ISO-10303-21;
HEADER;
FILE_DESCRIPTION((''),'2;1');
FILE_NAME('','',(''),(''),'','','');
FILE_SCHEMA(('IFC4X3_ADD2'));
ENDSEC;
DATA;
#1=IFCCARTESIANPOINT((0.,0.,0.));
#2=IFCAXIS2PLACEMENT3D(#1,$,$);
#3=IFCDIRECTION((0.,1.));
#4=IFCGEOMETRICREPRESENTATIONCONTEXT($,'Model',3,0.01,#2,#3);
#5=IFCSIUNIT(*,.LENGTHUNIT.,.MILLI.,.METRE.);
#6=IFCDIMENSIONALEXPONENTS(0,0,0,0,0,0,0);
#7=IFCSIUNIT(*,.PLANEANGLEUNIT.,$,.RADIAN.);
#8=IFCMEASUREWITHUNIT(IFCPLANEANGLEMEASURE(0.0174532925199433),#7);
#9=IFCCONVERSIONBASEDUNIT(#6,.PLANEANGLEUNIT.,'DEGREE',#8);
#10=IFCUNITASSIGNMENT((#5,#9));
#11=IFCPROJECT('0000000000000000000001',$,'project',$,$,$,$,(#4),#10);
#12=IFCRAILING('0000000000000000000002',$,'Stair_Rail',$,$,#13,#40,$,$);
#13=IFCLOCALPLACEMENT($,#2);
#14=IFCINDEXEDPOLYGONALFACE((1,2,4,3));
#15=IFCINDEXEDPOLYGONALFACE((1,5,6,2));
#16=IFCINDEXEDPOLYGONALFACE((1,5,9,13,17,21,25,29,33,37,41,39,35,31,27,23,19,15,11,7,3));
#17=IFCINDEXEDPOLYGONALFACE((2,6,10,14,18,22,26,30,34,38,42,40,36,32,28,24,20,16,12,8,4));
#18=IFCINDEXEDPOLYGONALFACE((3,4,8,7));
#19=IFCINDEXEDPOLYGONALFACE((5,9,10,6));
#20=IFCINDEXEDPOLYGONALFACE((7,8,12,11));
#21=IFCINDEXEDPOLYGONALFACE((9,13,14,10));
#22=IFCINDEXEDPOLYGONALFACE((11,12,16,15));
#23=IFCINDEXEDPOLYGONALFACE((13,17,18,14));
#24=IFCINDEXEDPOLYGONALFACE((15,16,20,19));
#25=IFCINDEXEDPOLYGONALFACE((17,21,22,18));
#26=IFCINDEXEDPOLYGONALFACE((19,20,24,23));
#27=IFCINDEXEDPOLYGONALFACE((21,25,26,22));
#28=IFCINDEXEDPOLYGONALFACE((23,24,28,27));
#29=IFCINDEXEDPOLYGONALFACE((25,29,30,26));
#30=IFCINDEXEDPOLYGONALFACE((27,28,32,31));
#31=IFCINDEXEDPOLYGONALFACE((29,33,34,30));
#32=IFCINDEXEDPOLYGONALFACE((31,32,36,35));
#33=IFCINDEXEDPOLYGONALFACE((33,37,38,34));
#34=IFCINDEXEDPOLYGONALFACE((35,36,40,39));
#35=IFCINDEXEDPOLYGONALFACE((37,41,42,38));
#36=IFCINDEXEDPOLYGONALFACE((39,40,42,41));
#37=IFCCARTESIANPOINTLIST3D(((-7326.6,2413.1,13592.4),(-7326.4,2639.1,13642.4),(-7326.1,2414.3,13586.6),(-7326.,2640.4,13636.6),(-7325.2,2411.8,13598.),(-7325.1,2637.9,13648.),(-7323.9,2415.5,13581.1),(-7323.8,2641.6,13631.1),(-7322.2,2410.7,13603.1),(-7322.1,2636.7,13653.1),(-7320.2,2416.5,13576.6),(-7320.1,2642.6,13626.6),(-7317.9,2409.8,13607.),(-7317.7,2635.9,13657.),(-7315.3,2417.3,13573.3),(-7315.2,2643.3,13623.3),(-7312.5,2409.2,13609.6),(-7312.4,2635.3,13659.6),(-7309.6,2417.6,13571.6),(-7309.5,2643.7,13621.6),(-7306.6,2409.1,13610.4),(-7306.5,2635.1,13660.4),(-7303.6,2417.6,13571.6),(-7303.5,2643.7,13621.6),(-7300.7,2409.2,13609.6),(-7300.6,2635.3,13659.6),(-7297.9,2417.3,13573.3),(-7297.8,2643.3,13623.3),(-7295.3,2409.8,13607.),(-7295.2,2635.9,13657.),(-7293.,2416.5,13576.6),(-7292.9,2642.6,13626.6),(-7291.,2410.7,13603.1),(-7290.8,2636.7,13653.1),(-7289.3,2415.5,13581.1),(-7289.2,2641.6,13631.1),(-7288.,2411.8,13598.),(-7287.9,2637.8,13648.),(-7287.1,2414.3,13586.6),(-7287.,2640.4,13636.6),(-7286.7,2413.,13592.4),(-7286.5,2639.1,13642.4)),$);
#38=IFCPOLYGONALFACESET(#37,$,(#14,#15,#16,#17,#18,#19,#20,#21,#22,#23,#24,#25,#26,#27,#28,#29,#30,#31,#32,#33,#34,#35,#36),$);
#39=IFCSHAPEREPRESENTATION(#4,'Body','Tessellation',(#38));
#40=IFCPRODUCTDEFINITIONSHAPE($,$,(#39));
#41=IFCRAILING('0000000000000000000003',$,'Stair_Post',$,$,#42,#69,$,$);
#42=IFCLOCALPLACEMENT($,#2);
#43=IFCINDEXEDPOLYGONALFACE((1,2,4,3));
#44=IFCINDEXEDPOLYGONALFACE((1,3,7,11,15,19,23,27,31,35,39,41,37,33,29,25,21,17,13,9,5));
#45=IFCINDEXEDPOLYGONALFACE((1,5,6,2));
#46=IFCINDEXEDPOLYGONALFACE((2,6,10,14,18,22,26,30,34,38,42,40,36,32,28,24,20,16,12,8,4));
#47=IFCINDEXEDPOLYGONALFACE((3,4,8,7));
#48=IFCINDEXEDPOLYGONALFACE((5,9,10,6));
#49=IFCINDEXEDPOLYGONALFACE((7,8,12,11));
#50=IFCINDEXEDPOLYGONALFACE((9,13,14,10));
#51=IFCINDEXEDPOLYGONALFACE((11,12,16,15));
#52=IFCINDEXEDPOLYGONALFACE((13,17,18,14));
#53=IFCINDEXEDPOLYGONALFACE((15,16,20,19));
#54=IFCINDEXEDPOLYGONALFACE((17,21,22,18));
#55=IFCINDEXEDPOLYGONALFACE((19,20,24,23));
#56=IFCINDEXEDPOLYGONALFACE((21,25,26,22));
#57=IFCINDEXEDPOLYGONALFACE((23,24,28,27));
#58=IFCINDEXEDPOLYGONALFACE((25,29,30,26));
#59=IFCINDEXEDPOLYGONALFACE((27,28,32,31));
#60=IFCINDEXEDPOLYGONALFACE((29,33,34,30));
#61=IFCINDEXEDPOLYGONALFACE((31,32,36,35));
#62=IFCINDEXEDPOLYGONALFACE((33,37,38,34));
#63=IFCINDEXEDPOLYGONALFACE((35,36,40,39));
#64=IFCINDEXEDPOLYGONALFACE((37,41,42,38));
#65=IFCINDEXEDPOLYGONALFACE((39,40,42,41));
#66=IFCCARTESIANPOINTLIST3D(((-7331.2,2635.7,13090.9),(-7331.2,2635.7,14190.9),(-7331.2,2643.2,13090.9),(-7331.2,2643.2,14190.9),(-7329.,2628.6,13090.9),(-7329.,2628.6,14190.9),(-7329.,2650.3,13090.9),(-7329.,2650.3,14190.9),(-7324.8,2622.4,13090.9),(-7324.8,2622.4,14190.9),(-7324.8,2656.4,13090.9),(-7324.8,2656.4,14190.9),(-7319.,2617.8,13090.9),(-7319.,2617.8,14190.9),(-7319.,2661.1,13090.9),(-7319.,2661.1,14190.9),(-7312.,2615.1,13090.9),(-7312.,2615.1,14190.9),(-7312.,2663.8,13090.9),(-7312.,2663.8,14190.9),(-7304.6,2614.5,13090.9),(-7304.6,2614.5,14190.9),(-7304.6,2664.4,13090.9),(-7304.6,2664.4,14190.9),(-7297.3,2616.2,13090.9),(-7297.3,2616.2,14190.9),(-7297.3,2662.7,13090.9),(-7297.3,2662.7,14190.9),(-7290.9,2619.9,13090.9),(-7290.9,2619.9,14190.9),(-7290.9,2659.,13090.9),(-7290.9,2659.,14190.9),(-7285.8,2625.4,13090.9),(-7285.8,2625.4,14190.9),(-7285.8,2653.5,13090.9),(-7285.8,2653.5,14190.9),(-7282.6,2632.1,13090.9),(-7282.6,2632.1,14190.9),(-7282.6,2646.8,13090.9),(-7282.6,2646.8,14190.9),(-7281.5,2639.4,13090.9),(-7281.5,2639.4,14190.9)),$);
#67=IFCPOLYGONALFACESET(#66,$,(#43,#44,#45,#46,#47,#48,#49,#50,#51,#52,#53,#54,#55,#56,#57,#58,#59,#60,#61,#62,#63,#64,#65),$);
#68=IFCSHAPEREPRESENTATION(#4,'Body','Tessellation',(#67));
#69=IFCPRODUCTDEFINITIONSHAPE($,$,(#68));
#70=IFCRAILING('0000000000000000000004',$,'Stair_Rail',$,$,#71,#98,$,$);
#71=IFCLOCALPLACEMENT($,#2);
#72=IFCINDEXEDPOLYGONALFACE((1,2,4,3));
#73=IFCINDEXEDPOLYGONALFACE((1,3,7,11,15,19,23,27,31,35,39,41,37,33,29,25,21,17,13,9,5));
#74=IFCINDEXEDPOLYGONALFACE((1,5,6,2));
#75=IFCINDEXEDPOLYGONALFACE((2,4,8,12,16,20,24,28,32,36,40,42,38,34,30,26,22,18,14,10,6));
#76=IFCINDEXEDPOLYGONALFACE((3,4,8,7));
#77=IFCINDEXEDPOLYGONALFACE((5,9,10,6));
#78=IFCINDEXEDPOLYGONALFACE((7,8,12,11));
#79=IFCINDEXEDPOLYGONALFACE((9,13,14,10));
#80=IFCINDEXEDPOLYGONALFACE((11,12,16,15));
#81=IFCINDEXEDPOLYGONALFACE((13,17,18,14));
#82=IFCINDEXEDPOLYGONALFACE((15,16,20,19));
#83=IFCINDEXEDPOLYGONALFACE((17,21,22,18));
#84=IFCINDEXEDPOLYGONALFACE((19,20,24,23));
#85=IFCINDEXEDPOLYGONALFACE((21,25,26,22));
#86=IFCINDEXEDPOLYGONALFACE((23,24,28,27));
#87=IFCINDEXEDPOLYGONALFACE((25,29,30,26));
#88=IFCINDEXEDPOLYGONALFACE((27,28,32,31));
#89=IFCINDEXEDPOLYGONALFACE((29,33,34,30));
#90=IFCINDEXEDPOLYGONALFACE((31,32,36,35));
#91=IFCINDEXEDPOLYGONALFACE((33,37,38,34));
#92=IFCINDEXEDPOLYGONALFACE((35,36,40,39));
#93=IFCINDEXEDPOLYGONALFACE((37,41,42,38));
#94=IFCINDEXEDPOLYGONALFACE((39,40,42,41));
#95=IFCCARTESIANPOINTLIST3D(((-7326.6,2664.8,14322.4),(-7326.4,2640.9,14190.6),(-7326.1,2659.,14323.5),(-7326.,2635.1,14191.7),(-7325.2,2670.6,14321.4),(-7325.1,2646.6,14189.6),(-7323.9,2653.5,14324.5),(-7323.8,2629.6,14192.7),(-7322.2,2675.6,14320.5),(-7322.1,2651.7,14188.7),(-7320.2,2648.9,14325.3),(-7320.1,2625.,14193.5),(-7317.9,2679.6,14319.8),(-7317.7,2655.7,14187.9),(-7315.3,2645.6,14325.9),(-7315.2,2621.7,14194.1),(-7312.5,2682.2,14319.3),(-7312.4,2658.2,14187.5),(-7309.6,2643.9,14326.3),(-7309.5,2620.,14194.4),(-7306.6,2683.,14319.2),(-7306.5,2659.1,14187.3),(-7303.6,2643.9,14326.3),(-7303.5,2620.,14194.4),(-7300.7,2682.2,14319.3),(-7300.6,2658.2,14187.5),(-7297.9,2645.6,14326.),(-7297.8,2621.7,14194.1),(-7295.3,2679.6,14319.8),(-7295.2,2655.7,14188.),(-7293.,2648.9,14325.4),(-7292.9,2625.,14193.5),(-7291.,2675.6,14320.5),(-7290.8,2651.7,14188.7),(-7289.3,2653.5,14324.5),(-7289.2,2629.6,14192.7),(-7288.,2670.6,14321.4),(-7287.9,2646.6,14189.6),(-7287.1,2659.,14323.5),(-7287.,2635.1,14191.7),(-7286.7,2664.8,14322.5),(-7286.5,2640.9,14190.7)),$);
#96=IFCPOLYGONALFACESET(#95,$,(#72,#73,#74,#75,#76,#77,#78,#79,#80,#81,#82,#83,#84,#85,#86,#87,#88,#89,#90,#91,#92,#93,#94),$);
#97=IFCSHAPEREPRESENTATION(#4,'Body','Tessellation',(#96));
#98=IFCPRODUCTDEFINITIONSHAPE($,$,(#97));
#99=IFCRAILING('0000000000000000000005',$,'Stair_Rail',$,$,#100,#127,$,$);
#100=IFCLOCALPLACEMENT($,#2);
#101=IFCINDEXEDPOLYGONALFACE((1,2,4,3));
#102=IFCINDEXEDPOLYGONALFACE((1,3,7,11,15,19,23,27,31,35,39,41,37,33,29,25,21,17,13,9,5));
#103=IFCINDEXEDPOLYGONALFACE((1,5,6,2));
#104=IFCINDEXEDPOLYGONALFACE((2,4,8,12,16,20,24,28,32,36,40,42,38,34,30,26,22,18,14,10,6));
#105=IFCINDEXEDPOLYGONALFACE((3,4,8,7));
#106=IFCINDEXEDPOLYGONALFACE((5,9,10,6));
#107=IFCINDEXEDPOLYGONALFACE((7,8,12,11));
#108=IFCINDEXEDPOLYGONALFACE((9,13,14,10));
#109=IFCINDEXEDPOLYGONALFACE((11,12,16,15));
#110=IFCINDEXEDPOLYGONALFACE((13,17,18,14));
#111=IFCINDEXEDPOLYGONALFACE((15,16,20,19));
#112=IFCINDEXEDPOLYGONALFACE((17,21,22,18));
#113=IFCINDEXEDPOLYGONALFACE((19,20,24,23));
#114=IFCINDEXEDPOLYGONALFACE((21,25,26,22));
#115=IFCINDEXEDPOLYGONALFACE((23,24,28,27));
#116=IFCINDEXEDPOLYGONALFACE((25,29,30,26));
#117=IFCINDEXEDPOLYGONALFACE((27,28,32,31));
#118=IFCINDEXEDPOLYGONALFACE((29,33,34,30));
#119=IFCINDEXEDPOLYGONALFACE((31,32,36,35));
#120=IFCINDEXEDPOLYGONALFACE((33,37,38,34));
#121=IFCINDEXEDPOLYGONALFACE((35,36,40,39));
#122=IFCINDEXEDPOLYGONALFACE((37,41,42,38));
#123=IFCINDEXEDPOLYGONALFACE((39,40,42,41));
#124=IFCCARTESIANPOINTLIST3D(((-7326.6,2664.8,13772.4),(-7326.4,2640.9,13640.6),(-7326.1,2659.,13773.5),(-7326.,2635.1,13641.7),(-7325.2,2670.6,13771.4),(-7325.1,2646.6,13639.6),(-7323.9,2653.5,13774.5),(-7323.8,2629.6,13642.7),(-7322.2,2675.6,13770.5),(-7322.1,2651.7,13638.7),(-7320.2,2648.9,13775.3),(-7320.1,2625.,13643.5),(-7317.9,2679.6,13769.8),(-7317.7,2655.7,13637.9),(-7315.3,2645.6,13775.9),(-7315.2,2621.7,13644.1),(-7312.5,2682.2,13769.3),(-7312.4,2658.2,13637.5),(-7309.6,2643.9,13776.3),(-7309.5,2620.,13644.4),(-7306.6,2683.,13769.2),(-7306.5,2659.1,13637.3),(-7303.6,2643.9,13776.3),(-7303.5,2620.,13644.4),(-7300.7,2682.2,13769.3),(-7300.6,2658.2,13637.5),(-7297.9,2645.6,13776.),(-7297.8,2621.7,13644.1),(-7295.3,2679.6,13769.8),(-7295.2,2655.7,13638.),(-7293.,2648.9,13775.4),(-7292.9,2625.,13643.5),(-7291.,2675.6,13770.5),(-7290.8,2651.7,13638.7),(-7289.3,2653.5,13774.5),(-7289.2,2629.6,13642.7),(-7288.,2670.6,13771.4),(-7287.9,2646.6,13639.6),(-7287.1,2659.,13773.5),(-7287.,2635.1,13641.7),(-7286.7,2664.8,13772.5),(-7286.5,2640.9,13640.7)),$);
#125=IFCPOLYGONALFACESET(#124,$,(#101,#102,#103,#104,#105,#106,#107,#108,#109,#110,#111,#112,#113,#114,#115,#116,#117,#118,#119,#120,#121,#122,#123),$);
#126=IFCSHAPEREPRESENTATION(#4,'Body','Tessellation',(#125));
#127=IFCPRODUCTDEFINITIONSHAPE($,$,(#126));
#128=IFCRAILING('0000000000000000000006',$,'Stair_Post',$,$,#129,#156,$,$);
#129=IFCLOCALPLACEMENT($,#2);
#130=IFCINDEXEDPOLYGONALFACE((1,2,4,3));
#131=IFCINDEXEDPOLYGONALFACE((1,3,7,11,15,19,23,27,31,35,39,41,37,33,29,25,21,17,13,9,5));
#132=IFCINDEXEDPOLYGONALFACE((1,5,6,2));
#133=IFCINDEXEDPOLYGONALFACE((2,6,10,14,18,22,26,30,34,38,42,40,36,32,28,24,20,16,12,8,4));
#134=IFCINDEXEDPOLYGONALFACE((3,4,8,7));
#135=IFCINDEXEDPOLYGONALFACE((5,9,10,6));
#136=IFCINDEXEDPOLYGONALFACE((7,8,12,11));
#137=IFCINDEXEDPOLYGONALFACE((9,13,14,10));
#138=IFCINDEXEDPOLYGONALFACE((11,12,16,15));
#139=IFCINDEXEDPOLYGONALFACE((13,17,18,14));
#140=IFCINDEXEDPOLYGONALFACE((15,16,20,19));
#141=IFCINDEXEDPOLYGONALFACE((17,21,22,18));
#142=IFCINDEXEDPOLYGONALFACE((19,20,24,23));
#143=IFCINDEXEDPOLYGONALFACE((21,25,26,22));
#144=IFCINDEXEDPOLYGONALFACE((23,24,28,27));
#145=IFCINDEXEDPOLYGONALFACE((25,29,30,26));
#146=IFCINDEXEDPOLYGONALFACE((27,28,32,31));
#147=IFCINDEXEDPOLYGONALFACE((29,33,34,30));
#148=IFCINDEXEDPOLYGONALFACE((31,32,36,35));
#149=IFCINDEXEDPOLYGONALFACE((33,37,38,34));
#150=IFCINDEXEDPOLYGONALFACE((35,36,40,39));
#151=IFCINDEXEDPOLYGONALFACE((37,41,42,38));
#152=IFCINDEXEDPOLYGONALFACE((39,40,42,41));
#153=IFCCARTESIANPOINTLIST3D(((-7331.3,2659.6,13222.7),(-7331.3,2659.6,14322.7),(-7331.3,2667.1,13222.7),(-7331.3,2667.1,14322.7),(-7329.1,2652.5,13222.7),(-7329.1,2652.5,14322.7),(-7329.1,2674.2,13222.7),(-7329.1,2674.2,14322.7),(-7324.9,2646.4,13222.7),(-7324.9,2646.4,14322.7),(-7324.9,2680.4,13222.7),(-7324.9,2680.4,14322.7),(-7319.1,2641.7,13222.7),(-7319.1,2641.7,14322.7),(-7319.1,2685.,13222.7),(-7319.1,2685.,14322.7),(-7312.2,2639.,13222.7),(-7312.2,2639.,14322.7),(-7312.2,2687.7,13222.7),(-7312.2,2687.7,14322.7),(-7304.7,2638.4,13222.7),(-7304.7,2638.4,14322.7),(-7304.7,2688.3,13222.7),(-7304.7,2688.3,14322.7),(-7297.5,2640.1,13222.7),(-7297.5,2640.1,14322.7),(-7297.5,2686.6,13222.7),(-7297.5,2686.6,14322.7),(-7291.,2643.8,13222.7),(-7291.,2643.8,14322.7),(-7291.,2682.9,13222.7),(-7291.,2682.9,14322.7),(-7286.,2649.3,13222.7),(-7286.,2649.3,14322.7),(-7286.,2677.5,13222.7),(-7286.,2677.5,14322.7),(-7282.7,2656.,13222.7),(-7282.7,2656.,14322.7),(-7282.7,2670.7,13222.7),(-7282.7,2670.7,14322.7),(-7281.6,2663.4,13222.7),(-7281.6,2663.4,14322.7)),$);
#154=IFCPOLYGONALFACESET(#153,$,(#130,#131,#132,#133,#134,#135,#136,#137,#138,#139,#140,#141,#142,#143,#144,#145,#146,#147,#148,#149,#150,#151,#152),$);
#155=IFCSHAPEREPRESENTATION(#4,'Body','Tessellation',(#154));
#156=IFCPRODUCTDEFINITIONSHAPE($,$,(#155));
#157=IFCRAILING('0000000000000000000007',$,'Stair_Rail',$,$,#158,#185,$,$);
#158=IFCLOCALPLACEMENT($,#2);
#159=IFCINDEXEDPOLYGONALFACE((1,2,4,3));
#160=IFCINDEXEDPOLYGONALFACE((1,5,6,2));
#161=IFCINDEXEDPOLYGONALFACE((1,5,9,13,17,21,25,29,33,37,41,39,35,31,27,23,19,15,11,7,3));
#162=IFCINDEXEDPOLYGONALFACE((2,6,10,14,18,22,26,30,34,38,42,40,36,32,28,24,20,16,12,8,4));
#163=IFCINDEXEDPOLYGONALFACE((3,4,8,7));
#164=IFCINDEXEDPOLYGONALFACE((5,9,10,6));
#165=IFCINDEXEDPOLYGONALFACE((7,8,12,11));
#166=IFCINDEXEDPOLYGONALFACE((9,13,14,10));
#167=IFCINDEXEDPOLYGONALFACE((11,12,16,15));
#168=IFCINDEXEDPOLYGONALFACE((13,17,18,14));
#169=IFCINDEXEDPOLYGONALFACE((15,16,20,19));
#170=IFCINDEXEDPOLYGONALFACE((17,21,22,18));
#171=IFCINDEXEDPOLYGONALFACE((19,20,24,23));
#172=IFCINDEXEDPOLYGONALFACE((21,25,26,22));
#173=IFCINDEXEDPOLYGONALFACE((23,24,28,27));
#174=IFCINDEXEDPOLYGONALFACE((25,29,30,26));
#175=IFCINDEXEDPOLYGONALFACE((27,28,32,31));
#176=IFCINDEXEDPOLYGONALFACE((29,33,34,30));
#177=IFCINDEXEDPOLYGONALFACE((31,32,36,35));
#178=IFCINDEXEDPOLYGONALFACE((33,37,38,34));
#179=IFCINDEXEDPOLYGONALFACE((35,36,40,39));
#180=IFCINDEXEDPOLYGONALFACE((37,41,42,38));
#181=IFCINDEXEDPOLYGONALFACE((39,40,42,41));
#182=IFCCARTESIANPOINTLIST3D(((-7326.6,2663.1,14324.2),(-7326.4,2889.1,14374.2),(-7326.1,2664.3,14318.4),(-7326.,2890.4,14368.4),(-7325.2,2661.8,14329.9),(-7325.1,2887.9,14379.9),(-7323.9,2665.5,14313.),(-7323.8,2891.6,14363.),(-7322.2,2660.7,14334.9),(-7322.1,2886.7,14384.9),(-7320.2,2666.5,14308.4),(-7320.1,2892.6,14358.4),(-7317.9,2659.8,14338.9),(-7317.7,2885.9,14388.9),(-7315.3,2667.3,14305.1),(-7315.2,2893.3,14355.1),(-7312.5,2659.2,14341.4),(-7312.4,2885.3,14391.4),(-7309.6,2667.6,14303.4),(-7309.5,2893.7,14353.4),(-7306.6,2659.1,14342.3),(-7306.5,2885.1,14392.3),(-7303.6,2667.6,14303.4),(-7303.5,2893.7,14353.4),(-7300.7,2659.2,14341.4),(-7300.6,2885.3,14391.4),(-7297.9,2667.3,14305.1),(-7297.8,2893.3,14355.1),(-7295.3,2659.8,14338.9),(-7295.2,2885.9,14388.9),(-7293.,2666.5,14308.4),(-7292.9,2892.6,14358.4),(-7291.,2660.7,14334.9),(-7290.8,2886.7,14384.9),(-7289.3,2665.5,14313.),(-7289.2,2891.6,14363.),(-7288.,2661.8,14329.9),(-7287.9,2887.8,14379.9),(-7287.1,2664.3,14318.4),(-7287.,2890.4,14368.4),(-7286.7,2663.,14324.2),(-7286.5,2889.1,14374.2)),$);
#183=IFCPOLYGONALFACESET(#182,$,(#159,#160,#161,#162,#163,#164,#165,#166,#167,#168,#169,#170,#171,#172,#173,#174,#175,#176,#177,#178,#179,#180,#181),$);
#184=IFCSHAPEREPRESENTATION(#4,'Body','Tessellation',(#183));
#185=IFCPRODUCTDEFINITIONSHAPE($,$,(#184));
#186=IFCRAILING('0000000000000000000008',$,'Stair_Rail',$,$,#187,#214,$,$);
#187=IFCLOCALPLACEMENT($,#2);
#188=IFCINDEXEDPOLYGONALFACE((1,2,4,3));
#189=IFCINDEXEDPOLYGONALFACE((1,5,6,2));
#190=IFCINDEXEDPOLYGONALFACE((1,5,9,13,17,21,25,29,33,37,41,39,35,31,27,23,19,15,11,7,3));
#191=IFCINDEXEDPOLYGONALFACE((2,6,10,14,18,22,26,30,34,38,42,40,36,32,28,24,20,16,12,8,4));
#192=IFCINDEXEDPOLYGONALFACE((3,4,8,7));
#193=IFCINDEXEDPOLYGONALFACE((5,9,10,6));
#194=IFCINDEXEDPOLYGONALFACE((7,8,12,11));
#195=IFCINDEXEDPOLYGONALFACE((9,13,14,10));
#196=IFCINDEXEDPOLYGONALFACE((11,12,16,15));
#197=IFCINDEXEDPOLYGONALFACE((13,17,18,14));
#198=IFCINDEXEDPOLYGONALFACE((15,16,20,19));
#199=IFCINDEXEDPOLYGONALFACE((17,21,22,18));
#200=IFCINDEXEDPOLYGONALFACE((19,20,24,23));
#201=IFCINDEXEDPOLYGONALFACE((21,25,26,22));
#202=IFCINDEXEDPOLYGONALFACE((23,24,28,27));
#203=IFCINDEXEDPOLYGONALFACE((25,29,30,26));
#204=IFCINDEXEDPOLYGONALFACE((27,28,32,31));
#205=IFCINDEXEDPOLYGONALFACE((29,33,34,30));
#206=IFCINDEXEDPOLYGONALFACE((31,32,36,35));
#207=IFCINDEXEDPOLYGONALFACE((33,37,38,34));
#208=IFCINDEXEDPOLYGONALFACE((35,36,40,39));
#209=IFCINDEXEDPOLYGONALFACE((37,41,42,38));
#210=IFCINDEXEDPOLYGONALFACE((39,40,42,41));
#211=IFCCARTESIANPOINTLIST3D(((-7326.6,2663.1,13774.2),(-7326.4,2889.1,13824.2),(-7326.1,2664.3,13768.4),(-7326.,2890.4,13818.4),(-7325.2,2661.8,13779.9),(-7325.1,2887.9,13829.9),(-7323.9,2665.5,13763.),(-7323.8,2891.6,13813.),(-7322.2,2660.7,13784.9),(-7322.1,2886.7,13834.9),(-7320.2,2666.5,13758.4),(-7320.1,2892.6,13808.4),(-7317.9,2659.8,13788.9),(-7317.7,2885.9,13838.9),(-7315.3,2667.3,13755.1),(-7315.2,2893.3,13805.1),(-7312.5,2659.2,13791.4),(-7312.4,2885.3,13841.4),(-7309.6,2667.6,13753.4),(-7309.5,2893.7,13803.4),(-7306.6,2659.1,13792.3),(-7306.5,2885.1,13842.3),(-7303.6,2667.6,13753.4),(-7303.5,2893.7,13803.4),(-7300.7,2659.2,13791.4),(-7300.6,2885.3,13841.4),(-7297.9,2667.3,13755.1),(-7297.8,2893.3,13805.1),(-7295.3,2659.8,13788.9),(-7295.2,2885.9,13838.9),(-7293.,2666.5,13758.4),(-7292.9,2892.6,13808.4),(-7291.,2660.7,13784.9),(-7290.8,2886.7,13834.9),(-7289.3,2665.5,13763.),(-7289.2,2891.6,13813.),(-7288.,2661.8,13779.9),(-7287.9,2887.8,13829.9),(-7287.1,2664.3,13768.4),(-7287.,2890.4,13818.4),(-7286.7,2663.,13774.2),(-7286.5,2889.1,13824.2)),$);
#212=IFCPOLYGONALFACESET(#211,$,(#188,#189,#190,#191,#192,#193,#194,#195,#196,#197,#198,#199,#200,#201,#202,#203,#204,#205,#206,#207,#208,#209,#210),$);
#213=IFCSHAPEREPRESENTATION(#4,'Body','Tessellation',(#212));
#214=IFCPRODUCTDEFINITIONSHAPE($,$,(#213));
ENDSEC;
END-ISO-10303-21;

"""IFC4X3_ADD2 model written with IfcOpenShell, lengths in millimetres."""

from ifc_helpers import new_model, entity, si_unit, converted_unit, direction, frame, origin, context, project, circle, extrude, element, save


model = new_model("IFC4X3_ADD2")

# Units and contexts
model_context = context("Model", 3, precision=0.01, world=origin(), true_north=direction((0.0, 1.0)))
ifc_project = project(units=[si_unit("LENGTHUNIT", "METRE", prefix="MILLI"), converted_unit("PLANEANGLEUNIT", "DEGREE", entity("IfcPlaneAngleMeasure", 0.0174532925199433), si_unit("PLANEANGLEUNIT", "RADIAN"), dimensions=[0, 0, 0, 0, 0, 0, 0])], contexts=[model_context])

# Railings
element("IfcRailing", 1, Name="Stair_Rail", context=model_context, shape_type="SweptSolid", body=[
    entity("IfcSweptDiskSolid", entity("IfcPolyline", [entity("IfcCartesianPoint", [-7306.6, 2413.4, 13590.9]), entity("IfcCartesianPoint", [-7306.5, 2639.4, 13640.9])]), 20.0),
])
element("IfcRailing", 2, Name="Stair_Post", context=model_context, shape_type="SweptSolid", body=[
    extrude(circle(Radius=25.0), frame((-7306.5, 2639.4, 13090.9)), (0.0, 0.0, 1.0), 1100.0),
])
element("IfcRailing", 3, Name="Stair_Rail", context=model_context, shape_type="SweptSolid", body=[
    entity("IfcSweptDiskSolid", entity("IfcPolyline", [entity("IfcCartesianPoint", [-7306.5, 2639.4, 14190.9]), entity("IfcCartesianPoint", [-7306.6, 2663.4, 14322.7])]), 20.0),
])
element("IfcRailing", 4, Name="Stair_Rail", context=model_context, shape_type="SweptSolid", body=[
    entity("IfcSweptDiskSolid", entity("IfcPolyline", [entity("IfcCartesianPoint", [-7306.5, 2639.4, 13640.9]), entity("IfcCartesianPoint", [-7306.6, 2663.4, 13772.7])]), 20.0),
])
element("IfcRailing", 5, Name="Stair_Post", context=model_context, shape_type="SweptSolid", body=[
    extrude(circle(Radius=25.0), frame((-7306.6, 2663.4, 13222.7)), (0.0, 0.0, 1.0), 1100.0),
])
element("IfcRailing", 6, Name="Stair_Rail", context=model_context, shape_type="SweptSolid", body=[
    entity("IfcSweptDiskSolid", entity("IfcPolyline", [entity("IfcCartesianPoint", [-7306.6, 2663.4, 14322.7]), entity("IfcCartesianPoint", [-7306.5, 2889.4, 14372.7])]), 20.0),
])
element("IfcRailing", 7, Name="Stair_Rail", context=model_context, shape_type="SweptSolid", body=[
    entity("IfcSweptDiskSolid", entity("IfcPolyline", [entity("IfcCartesianPoint", [-7306.6, 2663.4, 13772.7]), entity("IfcCartesianPoint", [-7306.5, 2889.4, 13822.7])]), 20.0),
])

save(model, "model.ifc")
